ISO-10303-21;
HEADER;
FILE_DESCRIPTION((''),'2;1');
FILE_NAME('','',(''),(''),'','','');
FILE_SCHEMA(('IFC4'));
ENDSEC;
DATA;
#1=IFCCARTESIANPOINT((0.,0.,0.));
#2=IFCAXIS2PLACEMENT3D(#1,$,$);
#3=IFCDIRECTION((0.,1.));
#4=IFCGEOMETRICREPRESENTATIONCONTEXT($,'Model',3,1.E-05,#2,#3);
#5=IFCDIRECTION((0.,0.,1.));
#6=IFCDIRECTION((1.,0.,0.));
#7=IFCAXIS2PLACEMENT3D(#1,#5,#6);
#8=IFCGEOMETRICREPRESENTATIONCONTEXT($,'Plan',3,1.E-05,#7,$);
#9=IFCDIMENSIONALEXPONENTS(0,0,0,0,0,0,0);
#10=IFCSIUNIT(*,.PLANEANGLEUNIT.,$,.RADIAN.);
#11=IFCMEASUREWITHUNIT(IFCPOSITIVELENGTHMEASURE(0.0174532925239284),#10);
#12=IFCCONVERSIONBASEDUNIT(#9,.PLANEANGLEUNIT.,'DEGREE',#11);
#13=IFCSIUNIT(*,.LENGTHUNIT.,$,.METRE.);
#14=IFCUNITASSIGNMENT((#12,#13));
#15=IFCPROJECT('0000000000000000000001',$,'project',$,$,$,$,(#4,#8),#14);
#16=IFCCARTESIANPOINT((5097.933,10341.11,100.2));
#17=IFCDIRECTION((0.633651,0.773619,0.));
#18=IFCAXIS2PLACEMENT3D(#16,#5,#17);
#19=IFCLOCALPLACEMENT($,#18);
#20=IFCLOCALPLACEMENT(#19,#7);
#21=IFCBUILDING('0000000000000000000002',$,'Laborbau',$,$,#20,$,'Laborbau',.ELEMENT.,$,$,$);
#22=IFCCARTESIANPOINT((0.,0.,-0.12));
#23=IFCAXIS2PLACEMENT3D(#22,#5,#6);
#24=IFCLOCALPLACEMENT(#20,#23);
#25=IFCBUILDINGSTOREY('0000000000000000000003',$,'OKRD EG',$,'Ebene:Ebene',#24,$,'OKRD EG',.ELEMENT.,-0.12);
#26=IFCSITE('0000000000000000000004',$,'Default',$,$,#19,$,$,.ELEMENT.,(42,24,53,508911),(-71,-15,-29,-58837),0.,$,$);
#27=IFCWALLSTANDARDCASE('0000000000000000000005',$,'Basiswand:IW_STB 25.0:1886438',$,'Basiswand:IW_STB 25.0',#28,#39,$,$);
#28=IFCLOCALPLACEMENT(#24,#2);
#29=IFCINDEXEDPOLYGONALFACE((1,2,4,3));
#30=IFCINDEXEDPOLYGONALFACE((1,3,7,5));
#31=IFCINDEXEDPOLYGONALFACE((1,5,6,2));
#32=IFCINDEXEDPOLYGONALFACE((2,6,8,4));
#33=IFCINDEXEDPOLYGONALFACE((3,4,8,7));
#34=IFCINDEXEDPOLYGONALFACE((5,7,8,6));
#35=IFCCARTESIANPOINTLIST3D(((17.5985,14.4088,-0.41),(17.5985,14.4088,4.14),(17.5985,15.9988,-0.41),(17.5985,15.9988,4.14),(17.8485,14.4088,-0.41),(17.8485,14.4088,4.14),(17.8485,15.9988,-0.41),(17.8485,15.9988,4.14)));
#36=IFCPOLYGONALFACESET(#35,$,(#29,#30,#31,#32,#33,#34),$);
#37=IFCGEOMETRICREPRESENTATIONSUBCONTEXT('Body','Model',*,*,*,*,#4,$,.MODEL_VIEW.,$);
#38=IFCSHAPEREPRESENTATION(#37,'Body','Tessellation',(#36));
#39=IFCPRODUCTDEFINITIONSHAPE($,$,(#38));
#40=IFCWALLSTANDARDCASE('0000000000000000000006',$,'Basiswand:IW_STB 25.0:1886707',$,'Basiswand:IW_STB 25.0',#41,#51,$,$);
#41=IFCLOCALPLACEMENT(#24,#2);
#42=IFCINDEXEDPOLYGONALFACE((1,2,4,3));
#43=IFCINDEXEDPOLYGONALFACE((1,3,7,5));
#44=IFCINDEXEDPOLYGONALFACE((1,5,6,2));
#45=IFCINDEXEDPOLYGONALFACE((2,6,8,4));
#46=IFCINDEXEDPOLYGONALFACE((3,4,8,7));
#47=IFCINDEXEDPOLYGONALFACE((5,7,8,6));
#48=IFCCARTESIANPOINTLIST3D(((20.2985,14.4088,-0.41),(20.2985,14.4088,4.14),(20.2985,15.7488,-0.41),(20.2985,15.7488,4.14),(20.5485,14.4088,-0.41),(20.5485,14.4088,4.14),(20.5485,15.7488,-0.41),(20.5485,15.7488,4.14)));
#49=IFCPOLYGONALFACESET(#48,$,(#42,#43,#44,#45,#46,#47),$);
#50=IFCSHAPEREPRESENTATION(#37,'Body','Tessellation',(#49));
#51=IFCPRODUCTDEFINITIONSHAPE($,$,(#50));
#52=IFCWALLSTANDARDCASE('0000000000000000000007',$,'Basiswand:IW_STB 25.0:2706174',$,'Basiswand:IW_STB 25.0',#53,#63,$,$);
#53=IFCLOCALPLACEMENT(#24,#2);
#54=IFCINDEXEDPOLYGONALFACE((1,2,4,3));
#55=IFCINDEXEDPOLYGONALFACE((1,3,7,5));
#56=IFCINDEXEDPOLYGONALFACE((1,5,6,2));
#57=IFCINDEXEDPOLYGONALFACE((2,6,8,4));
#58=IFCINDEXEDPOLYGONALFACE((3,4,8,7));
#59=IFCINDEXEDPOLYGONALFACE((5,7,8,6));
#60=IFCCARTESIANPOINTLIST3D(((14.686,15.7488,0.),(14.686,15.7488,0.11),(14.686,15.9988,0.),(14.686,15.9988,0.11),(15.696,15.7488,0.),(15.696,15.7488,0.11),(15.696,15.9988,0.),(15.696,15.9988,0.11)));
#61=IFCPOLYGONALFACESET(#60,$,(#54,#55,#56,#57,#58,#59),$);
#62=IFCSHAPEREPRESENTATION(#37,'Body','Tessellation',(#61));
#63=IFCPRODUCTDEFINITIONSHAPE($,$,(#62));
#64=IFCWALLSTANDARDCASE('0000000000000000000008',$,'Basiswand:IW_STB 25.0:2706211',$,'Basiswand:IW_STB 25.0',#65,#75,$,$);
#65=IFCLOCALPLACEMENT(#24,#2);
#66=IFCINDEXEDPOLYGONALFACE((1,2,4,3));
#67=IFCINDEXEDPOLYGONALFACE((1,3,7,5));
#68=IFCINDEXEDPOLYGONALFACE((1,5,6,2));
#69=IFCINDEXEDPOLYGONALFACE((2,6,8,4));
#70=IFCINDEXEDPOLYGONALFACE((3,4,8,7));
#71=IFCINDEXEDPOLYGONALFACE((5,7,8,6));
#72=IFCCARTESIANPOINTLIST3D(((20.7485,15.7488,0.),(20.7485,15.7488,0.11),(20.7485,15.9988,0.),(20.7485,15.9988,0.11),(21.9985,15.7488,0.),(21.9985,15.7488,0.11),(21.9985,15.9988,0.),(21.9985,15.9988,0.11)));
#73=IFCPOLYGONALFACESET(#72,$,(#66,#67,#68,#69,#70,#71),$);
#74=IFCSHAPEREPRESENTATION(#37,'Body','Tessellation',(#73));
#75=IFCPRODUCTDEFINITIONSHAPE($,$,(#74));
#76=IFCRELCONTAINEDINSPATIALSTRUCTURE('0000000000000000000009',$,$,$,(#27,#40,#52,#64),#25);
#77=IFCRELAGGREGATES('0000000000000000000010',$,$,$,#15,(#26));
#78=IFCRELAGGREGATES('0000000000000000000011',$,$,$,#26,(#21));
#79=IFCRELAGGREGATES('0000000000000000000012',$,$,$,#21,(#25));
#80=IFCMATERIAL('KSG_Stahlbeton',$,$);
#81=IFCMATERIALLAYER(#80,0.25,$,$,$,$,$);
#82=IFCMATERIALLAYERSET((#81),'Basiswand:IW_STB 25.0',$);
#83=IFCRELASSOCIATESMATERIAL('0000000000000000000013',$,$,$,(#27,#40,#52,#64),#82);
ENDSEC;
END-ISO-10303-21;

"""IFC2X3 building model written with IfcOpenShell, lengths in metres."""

from ifc_helpers import new_model, entity, si_unit, converted_unit, direction, frame, frame_2d, origin, origin_with_axes, place, context, subcontext, project, spatial, rectangle, extrude, material, layer, layer_set, layer_usage, element, save


model = new_model("IFC2X3")

# Units and contexts
model_context = context("Model", 3, precision=1e-05, world=origin(), true_north=direction((0.0, 1.0)))
plan_context = context("Plan", 3, precision=1e-05, world=origin_with_axes())
body_context = subcontext(model_context, "Body", "Model", "MODEL_VIEW")
ifc_project = project(units=[converted_unit("PLANEANGLEUNIT", "DEGREE", entity("IfcPositiveLengthMeasure", 0.0174532925239284), si_unit("PLANEANGLEUNIT", "RADIAN"), dimensions=[0, 0, 0, 0, 0, 0, 0]), si_unit("LENGTHUNIT", "METRE")], contexts=[model_context, plan_context])

# Site, building, storey
site_placement = place(None, frame((5097.933, 10341.11, 100.2), z_axis=(0.0, 0.0, 1.0), x_axis=(0.633651, 0.773619, 0.0)))
site = spatial("IfcSite", under=ifc_project, at=site_placement, Name="Default", CompositionType="ELEMENT", RefLatitude=(42, 24, 53, 508911), RefLongitude=(-71, -15, -29, -58837), RefElevation=0.0)
building_placement = place(site_placement, origin_with_axes())
building = spatial("IfcBuilding", under=site, at=building_placement, Name="Laborbau", LongName="Laborbau", CompositionType="ELEMENT")
storey_placement = place(building_placement, frame((0.0, 0.0, -0.12), z_axis=(0.0, 0.0, 1.0), x_axis=(1.0, 0.0, 0.0)))
storey = spatial("IfcBuildingStorey", under=building, at=storey_placement, Name="OKRD EG", ObjectType="Ebene:Ebene", LongName="OKRD EG", CompositionType="ELEMENT", Elevation=-0.12)

# Shared definitions
ifc_material = material(Name="KSG_Stahlbeton")

# Shared definitions
ifc_layer_1 = layer(ifc_material, 0.25)
ifc_layer_set_1 = layer_set([ifc_layer_1], Name="Basiswand:IW_STB 25.0")

# Walls
ifc_layer_usage_1 = layer_usage(ifc_layer_set_1, "AXIS2", "POSITIVE", -0.125)
wall_1_placement = place(storey_placement, frame((17.7235, 14.4088, -0.41), z_axis=(0.0, 0.0, 1.0), x_axis=(0.0, 1.0, 0.0)))
element("IfcWallStandardCase", 1, at=wall_1_placement, inside=storey, material=ifc_layer_usage_1, Name="Basiswand:IW_STB 25.0:1886438", ObjectType="Basiswand:IW_STB 25.0", context=body_context, shape_type="SweptSolid", body=[
    extrude(rectangle(XDim=1.59, YDim=0.25, at=frame_2d((0.795, 0.0), x_axis=(-1.0, 0.0))), origin(), (0.0, 0.0, 1.0), 4.55),
])
ifc_layer_usage_2 = layer_usage(ifc_layer_set_1, "AXIS2", "POSITIVE", -0.125)
wall_2_placement = place(storey_placement, frame((20.4235, 14.4088, -0.41), z_axis=(0.0, 0.0, 1.0), x_axis=(0.0, 1.0, 0.0)))
element("IfcWallStandardCase", 2, at=wall_2_placement, inside=storey, material=ifc_layer_usage_2, Name="Basiswand:IW_STB 25.0:1886707", ObjectType="Basiswand:IW_STB 25.0", context=body_context, shape_type="SweptSolid", body=[
    extrude(rectangle(XDim=1.34, YDim=0.25, at=frame_2d((0.67, 0.0), x_axis=(-1.0, 0.0))), origin(), (0.0, 0.0, 1.0), 4.55),
])
ifc_layer_usage_3 = layer_usage(ifc_layer_set_1, "AXIS2", "NEGATIVE", 0.125)
wall_3_placement = place(storey_placement, frame((14.686, 15.8738, 0.0), z_axis=(0.0, 0.0, 1.0), x_axis=(1.0, 0.0, 0.0)))
element("IfcWallStandardCase", 3, at=wall_3_placement, inside=storey, material=ifc_layer_usage_3, Name="Basiswand:IW_STB 25.0:2706174", ObjectType="Basiswand:IW_STB 25.0", context=body_context, shape_type="SweptSolid", body=[
    extrude(rectangle(XDim=1.01, YDim=0.25, at=frame_2d((0.505, 0.0), x_axis=(-1.0, 0.0))), origin(), (0.0, 0.0, 1.0), 0.11),
])
ifc_layer_usage_4 = layer_usage(ifc_layer_set_1, "AXIS2", "NEGATIVE", 0.125)
wall_4_placement = place(storey_placement, frame((20.7485, 15.8738, 0.0), z_axis=(0.0, 0.0, 1.0), x_axis=(1.0, 0.0, 0.0)))
element("IfcWallStandardCase", 4, at=wall_4_placement, inside=storey, material=ifc_layer_usage_4, Name="Basiswand:IW_STB 25.0:2706211", ObjectType="Basiswand:IW_STB 25.0", context=body_context, shape_type="SweptSolid", body=[
    extrude(rectangle(XDim=1.25, YDim=0.25, at=frame_2d((0.625, 0.0), x_axis=(-1.0, 0.0))), origin(), (0.0, 0.0, 1.0), 0.11),
])

save(model, "model.ifc")
